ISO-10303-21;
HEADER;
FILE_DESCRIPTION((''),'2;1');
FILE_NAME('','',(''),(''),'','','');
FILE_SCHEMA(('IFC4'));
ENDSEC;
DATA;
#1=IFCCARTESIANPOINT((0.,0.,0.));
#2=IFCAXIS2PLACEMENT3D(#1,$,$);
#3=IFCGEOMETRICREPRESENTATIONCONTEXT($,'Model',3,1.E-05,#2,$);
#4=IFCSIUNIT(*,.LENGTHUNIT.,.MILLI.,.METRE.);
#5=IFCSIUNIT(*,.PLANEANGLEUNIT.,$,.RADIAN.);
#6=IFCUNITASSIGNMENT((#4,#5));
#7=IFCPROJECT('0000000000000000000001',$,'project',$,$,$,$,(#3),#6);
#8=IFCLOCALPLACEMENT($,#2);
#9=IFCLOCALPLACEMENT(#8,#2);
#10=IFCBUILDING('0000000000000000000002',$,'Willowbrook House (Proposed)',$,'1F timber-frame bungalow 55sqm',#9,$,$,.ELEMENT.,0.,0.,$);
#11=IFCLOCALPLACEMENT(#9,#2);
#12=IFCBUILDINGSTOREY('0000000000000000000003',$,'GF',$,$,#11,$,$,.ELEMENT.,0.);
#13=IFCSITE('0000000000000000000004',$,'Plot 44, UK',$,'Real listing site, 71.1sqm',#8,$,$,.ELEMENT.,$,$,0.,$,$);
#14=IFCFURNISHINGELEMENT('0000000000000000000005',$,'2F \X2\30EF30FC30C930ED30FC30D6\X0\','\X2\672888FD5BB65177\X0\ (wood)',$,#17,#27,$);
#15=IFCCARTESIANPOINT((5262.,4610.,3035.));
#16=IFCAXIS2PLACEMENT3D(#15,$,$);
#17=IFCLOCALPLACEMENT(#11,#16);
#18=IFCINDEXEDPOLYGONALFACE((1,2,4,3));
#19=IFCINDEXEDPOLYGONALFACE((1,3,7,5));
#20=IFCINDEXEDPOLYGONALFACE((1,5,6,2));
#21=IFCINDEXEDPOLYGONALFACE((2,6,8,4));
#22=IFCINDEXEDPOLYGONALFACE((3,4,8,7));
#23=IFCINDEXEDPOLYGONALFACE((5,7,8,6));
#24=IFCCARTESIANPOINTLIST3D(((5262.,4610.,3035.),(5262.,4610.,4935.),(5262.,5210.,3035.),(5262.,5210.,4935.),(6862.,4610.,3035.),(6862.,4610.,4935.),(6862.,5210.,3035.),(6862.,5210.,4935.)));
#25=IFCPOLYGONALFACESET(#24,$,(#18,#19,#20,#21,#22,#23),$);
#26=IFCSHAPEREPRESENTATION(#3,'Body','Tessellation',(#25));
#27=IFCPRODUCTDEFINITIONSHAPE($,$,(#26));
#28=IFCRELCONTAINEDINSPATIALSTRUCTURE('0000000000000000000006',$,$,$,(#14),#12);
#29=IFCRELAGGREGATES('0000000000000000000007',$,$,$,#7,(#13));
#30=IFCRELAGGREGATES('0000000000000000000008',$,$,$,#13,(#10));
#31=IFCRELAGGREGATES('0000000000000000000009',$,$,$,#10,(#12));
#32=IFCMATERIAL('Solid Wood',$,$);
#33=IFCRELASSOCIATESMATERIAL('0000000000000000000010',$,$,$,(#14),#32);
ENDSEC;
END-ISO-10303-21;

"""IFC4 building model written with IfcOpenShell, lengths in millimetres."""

from ifc_helpers import new_model, si_unit, frame, frame_2d, origin, place, context, project, spatial, rectangle, extrude, material, element, save


model = new_model("IFC4")

# Units and contexts
model_context = context("Model", 3, precision=1e-05, world=origin())
ifc_project = project(units=[si_unit("LENGTHUNIT", "METRE", prefix="MILLI"), si_unit("PLANEANGLEUNIT", "RADIAN")], contexts=[model_context])

# Site, building, storey
site_placement = place(None, origin())
site = spatial("IfcSite", under=ifc_project, at=site_placement, Name="Plot 44, UK", ObjectType="Real listing site, 71.1sqm", CompositionType="ELEMENT", RefElevation=0.0)
building_placement = place(site_placement, origin())
building = spatial("IfcBuilding", under=site, at=building_placement, Name="Willowbrook House (Proposed)", ObjectType="1F timber-frame bungalow 55sqm", CompositionType="ELEMENT", ElevationOfRefHeight=0.0, ElevationOfTerrain=0.0)
storey_placement = place(building_placement, origin())
storey = spatial("IfcBuildingStorey", under=building, at=storey_placement, Name="GF", CompositionType="ELEMENT", Elevation=0.0)

# Shared definitions
ifc_material_1 = material(Name="Solid Wood")

# Furnishing element
furnishing_1_placement = place(storey_placement, frame((5262.0, 4610.0, 3035.0)))
element("IfcFurnishingElement", 1, at=furnishing_1_placement, inside=storey, material=ifc_material_1, Name="2F ワードローブ", Description="木製家具 (wood)", context=model_context, shape_type="SweptSolid", body=[
    extrude(rectangle(XDim=1600.0, YDim=600.0, at=frame_2d((800.0, 300.0))), frame((5262.0, 4610.0, 3035.0)), (0.0, 0.0, 1.0), 1900.0),
])

save(model, "model.ifc")
